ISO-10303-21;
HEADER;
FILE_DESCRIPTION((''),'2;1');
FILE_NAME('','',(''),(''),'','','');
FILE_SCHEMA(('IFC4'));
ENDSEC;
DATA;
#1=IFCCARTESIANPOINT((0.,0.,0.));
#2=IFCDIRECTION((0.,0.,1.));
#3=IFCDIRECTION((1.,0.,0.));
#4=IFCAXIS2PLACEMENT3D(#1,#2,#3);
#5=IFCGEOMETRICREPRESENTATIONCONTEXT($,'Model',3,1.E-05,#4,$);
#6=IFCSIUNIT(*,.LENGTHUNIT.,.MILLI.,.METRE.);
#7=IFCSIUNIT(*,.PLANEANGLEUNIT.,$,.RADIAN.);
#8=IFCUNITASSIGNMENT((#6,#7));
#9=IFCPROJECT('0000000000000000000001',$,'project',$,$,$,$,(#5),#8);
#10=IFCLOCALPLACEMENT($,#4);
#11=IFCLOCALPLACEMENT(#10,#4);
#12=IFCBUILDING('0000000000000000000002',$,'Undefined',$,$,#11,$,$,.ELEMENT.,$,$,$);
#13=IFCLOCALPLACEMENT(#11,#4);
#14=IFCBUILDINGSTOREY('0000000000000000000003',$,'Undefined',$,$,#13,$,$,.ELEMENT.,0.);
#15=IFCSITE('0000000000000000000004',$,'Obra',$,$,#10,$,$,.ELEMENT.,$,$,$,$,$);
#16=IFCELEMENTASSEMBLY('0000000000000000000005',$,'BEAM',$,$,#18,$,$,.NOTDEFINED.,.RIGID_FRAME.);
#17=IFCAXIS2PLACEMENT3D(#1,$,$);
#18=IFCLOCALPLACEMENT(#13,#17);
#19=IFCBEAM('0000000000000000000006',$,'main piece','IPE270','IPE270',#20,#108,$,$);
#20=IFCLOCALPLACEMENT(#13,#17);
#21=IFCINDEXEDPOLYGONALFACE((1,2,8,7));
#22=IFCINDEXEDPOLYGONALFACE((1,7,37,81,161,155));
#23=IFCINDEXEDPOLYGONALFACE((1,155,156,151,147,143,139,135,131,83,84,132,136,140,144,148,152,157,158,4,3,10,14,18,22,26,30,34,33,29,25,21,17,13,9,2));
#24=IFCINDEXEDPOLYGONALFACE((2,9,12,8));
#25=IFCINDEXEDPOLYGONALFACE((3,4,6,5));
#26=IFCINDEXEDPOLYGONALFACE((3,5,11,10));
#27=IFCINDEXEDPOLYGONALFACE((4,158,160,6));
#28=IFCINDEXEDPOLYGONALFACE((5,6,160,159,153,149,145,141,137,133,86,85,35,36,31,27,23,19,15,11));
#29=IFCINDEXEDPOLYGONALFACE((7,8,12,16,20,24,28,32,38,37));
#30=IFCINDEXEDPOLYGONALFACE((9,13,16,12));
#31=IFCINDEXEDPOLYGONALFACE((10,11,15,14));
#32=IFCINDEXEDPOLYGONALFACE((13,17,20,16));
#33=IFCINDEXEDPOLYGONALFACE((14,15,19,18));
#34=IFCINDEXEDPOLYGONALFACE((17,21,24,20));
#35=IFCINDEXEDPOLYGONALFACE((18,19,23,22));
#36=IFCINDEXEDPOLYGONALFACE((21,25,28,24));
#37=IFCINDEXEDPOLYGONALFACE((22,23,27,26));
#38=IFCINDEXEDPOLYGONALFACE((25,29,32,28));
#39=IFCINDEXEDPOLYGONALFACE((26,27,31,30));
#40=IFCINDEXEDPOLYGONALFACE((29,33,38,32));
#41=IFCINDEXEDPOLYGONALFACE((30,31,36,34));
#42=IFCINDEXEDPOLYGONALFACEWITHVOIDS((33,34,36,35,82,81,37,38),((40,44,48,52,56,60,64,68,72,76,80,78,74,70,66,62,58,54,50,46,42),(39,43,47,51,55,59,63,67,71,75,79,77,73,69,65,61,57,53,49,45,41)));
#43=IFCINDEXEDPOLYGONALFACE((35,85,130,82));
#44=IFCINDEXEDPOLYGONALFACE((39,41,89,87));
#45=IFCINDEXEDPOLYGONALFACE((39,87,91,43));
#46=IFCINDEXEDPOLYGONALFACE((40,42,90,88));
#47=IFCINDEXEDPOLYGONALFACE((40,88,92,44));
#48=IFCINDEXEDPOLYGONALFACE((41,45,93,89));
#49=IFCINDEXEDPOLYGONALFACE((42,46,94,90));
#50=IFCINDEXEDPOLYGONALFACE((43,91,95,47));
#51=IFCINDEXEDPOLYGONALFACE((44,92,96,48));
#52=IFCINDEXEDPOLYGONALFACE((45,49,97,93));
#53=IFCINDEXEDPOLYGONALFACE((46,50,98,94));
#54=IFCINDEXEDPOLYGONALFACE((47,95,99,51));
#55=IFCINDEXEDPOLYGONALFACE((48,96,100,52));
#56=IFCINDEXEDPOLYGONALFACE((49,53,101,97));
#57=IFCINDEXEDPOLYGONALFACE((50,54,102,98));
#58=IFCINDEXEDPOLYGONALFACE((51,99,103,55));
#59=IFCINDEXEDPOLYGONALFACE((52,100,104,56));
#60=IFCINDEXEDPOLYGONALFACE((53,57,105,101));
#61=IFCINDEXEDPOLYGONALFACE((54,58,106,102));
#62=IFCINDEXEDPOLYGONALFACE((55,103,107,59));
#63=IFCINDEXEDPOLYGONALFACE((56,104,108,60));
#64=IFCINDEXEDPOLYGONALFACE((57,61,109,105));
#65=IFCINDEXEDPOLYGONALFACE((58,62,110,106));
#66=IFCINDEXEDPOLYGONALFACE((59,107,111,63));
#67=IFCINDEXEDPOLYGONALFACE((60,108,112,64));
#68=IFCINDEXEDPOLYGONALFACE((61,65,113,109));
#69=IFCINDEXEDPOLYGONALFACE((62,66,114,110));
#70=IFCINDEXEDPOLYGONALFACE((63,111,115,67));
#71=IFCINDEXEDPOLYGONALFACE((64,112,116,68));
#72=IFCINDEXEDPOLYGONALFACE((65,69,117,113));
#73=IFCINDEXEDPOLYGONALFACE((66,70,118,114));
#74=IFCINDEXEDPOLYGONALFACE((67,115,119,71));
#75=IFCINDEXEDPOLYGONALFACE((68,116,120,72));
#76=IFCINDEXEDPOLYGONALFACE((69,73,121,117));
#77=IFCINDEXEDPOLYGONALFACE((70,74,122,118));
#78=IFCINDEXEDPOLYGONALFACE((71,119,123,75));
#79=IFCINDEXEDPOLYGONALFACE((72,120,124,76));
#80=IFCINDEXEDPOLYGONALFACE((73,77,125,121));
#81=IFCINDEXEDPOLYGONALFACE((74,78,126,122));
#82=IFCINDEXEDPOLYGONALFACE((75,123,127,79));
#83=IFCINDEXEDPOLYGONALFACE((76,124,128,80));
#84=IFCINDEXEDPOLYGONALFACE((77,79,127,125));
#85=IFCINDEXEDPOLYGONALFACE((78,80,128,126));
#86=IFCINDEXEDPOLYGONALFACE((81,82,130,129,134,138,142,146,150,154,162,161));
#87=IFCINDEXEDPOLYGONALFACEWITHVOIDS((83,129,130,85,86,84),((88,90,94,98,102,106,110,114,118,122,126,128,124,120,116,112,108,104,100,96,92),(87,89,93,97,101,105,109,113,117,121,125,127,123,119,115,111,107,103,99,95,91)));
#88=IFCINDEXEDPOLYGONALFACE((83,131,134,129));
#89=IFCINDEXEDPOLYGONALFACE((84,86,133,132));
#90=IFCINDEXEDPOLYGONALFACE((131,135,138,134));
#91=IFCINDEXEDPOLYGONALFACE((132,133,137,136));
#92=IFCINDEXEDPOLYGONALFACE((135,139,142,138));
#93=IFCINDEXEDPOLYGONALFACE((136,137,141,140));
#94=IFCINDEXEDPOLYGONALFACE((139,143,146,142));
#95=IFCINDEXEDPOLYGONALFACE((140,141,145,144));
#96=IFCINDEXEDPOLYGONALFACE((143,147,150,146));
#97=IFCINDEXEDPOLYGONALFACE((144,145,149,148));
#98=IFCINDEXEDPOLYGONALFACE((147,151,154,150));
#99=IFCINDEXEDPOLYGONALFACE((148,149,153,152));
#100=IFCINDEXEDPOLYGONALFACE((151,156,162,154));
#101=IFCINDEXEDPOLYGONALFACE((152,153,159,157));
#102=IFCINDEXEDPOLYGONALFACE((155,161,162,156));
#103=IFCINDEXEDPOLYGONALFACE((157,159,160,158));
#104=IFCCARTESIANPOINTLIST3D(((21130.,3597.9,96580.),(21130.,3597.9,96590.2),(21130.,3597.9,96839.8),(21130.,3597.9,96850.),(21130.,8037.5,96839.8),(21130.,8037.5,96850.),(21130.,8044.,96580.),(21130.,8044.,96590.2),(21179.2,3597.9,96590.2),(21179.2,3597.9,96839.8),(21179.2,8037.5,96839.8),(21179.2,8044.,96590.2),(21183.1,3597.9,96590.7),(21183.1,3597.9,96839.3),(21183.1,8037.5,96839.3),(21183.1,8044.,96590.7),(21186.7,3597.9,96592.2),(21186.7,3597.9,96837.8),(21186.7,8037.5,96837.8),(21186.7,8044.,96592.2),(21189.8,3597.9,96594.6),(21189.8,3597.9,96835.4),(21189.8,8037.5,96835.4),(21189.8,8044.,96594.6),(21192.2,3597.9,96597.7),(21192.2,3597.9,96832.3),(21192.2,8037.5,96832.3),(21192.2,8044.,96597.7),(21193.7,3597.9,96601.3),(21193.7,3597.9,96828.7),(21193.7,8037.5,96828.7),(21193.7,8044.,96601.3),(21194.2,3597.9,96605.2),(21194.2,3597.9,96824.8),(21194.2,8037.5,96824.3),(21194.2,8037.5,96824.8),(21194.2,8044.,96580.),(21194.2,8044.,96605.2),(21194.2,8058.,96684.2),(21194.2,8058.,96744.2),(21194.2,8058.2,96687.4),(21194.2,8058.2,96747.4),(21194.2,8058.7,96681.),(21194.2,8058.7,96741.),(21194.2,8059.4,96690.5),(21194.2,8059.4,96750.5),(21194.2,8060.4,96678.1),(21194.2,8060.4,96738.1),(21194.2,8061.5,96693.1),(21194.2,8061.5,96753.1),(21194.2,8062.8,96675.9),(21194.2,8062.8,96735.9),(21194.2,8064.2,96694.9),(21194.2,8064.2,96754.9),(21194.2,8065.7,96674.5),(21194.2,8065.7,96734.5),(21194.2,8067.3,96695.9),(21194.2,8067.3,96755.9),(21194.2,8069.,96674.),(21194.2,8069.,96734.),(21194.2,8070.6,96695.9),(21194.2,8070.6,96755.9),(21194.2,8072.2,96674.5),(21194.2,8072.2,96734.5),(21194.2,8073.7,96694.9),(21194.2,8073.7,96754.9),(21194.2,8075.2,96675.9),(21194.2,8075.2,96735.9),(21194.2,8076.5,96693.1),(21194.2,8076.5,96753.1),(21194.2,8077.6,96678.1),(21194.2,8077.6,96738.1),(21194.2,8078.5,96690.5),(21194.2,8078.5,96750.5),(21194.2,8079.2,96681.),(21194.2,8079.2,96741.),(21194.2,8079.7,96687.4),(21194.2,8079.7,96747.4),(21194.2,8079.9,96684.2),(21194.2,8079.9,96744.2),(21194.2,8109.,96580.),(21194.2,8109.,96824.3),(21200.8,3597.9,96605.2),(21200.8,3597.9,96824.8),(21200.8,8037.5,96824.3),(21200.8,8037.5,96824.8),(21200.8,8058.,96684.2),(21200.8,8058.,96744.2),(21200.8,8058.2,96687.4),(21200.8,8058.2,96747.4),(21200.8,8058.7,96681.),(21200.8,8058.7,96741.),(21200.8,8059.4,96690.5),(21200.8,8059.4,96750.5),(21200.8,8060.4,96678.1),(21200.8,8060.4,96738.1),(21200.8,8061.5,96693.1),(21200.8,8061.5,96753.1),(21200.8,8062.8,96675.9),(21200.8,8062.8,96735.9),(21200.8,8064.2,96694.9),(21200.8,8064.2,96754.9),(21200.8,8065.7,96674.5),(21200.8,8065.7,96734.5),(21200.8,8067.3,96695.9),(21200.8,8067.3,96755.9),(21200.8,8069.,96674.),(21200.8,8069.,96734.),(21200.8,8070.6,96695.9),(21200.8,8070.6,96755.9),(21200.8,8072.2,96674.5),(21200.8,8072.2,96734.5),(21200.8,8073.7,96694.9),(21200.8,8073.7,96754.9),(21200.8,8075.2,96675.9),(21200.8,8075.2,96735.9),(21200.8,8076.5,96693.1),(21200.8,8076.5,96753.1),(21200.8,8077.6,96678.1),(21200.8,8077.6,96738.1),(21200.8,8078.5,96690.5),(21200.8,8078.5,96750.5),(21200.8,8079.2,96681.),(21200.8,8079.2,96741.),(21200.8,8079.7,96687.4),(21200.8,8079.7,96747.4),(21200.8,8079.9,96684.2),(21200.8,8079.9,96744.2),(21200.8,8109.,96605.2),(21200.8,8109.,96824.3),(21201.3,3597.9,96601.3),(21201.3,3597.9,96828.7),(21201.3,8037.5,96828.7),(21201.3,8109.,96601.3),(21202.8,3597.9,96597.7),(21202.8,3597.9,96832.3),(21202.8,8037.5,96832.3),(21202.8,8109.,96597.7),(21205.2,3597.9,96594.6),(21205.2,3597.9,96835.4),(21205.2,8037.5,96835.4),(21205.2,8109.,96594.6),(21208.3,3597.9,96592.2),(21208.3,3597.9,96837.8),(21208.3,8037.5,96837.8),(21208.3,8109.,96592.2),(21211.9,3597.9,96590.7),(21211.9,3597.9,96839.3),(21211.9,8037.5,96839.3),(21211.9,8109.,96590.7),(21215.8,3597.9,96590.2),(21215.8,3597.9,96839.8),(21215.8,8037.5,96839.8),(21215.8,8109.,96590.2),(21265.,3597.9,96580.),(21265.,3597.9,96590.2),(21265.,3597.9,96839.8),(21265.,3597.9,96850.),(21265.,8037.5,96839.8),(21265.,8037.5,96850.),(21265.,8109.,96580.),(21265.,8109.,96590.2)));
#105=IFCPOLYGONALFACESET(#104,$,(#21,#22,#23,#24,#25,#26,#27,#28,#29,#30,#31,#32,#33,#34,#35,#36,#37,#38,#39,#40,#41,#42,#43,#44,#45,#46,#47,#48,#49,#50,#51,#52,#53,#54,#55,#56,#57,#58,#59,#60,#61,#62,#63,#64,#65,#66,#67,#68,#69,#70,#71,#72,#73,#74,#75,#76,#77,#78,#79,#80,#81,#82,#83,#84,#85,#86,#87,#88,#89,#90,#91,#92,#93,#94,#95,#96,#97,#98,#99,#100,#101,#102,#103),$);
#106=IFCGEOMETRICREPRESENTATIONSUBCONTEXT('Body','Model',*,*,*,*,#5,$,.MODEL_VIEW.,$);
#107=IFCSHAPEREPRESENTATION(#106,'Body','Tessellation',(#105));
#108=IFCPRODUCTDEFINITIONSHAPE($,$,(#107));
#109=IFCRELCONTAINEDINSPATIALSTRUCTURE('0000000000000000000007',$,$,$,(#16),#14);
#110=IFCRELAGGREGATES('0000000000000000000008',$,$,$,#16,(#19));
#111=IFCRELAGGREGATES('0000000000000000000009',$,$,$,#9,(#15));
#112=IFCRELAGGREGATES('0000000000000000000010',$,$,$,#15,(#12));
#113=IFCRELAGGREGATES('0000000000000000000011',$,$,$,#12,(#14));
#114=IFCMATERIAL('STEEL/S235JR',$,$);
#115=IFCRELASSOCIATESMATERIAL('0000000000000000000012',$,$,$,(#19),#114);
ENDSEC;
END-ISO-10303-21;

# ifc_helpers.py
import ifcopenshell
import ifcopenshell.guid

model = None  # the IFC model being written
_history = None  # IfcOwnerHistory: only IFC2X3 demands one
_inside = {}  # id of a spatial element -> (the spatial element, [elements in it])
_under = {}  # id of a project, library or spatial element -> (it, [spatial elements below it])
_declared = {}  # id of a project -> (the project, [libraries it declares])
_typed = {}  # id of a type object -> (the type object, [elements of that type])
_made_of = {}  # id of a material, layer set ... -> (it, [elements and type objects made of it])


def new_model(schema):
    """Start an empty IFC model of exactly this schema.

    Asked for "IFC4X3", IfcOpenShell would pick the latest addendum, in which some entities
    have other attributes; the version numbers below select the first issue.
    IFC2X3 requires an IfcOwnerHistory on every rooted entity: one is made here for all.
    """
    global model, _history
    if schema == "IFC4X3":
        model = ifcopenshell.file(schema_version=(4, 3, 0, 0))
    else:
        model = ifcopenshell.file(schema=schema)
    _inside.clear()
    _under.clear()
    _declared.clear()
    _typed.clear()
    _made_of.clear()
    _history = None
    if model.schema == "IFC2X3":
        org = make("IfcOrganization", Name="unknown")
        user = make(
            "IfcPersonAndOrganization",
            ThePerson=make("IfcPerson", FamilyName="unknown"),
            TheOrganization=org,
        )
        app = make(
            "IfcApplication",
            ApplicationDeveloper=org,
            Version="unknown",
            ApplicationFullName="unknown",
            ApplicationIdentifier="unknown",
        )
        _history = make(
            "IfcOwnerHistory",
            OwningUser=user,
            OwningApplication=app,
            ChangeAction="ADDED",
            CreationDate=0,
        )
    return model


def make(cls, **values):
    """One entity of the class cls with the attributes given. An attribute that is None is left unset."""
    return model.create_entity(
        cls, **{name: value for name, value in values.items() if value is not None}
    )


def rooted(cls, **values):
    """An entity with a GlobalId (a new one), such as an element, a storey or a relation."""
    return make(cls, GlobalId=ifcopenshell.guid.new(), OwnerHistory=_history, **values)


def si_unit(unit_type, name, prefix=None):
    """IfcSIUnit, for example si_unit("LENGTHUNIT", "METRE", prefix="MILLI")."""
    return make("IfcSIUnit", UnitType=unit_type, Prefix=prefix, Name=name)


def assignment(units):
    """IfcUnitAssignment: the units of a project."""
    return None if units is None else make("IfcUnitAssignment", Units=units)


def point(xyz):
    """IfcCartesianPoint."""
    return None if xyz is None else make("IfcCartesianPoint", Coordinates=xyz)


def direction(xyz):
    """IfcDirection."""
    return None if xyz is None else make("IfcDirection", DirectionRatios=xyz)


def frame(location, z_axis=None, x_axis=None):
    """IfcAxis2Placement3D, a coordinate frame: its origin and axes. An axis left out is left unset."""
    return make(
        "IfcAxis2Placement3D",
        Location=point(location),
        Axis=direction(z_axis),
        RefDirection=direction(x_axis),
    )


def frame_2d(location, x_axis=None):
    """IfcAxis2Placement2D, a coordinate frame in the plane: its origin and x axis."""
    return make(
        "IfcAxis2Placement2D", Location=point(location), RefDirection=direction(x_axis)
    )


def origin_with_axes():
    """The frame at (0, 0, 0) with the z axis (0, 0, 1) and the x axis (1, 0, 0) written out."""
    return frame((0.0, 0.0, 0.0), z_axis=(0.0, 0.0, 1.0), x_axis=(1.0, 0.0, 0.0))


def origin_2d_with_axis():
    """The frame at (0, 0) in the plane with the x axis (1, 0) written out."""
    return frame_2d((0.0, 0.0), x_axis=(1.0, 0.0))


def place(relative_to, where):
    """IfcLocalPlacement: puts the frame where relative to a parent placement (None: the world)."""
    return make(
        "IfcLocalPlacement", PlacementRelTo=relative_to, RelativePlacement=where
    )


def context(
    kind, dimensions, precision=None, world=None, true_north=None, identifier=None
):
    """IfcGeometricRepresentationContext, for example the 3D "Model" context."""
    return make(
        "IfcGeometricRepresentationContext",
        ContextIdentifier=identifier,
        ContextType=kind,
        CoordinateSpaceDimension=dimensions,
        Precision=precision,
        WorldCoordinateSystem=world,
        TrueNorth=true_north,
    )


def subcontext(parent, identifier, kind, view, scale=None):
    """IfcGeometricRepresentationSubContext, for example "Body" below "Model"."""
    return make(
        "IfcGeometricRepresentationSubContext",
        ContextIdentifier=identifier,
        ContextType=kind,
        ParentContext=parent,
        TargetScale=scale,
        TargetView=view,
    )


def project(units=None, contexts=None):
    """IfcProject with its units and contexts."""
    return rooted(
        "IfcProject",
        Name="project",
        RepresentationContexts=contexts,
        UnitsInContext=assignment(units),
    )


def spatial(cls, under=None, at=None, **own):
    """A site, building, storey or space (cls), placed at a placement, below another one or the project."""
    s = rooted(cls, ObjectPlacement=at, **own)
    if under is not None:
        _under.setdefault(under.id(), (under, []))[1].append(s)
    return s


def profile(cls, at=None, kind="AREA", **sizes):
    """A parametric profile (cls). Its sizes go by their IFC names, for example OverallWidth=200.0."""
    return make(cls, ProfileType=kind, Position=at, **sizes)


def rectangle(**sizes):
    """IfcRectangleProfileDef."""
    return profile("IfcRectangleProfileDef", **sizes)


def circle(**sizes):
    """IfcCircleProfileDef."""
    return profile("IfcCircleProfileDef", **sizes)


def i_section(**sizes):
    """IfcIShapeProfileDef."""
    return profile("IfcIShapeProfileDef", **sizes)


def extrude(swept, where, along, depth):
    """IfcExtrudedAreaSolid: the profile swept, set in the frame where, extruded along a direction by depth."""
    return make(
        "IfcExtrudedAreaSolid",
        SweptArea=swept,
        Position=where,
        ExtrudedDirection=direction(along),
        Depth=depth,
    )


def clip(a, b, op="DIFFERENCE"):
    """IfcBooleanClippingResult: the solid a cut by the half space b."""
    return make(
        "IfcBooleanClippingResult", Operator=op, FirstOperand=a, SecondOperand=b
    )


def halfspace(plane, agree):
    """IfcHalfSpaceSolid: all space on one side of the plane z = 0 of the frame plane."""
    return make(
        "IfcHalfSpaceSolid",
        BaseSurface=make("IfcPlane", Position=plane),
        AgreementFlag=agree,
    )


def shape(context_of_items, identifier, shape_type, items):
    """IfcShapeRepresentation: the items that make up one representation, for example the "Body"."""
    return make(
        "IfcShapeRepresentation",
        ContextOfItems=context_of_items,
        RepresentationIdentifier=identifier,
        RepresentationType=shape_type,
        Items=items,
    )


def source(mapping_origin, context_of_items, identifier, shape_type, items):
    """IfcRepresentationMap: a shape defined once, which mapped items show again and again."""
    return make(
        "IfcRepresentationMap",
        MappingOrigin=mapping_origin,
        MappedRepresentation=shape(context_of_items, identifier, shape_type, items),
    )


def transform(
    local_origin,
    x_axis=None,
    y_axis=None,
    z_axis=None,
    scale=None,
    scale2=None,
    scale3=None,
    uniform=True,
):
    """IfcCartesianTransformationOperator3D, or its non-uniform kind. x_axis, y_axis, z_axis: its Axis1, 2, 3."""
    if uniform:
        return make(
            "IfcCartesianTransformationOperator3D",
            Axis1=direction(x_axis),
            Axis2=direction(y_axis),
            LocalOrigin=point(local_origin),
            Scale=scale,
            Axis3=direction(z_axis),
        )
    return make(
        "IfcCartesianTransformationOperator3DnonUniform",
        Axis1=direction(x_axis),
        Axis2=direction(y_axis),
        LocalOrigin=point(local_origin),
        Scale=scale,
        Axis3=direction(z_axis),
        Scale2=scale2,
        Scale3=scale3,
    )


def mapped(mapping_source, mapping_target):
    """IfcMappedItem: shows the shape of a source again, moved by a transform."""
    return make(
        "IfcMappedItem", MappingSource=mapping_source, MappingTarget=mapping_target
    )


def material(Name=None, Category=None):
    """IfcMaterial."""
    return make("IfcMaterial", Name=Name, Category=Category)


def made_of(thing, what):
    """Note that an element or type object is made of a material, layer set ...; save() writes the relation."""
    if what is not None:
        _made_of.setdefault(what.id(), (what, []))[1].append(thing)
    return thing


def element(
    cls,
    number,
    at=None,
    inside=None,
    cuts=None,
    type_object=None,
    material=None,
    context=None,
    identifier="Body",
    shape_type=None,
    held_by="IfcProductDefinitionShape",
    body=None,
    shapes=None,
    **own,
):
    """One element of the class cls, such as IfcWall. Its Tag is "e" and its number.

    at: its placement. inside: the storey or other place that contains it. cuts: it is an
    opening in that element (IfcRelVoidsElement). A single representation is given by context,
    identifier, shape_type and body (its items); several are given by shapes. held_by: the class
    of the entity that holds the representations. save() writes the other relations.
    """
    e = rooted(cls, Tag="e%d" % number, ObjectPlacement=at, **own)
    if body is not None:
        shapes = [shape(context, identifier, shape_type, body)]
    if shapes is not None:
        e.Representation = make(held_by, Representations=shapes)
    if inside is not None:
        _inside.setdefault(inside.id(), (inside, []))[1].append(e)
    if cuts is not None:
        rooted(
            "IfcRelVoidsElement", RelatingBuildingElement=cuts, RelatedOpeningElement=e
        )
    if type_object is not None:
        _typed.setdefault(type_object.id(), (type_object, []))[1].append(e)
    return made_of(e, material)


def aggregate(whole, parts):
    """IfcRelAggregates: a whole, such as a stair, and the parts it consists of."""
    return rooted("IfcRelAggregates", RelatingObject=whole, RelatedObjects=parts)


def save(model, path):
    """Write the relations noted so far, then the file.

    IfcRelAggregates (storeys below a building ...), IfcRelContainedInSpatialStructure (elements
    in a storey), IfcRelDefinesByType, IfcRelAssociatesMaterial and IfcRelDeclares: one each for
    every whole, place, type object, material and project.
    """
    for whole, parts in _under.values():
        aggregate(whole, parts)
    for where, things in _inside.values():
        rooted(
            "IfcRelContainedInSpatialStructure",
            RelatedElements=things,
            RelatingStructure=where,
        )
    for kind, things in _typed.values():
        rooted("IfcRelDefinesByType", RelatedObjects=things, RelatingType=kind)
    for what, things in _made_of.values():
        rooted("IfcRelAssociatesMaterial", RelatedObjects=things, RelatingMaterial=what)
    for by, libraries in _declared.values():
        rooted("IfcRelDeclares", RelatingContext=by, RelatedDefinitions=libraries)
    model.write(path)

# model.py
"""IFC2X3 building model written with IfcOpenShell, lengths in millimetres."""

from ifc_helpers import new_model, si_unit, frame, origin_with_axes, origin_2d_with_axis, place, context, subcontext, project, spatial, rectangle, circle, i_section, extrude, clip, halfspace, source, transform, mapped, material, element, aggregate, save


model = new_model("IFC2X3")

# Units and contexts
model_context = context("Model", 3, precision=1e-05, world=origin_with_axes())
body_context = subcontext(model_context, "Body", "Model", "MODEL_VIEW")
ifc_project = project(units=[si_unit("LENGTHUNIT", "METRE", prefix="MILLI"), si_unit("PLANEANGLEUNIT", "RADIAN")], contexts=[model_context])

# Site, building, storey
site_placement = place(None, origin_with_axes())
site = spatial("IfcSite", under=ifc_project, at=site_placement, Name="Obra", CompositionType="ELEMENT")
building_placement = place(site_placement, origin_with_axes())
building = spatial("IfcBuilding", under=site, at=building_placement, Name="Undefined", CompositionType="ELEMENT")
storey_placement = place(building_placement, origin_with_axes())
storey = spatial("IfcBuildingStorey", under=building, at=storey_placement, Name="Undefined", CompositionType="ELEMENT", Elevation=0.0)

# Shared definitions
ifc_material = material(Name="STEEL/S235JR")

# Element assembly, beam, openings
assembly_1_placement = place(storey_placement, origin_with_axes())
assembly_1 = element("IfcElementAssembly", 1, at=assembly_1_placement, inside=storey, Name="BEAM", AssemblyPlace="NOTDEFINED", PredefinedType="RIGID_FRAME")
beam_1_placement = place(assembly_1_placement, frame((21197.5, 3598.0, 96715.0), z_axis=(0.0, 0.0, 1.0), x_axis=(0.0, 1.0, 0.0)))
beam_1 = element("IfcBeam", 2, at=beam_1_placement, material=ifc_material, Name="main piece", Description="IPE270", ObjectType="IPE270", context=body_context, shape_type="Clipping", body=[
    clip(extrude(i_section(OverallWidth=135.0, OverallDepth=270.0, WebThickness=6.6, FlangeThickness=10.2, FilletRadius=15.0, at=origin_2d_with_axis()), frame((4511.0, 0.0, 0.0), z_axis=(-1.0, 0.0, 0.0), x_axis=(0.0, -1.0, 0.0)), (0.0, 0.0, 1.0), 4511.0), halfspace(frame((4511.0, 0.0, -235.0), z_axis=(-1.0, 0.0, 0.0), x_axis=(0.0, 1.0, 0.0)), True)),
])
opening_1_placement = place(assembly_1_placement, frame((21197.5, 3598.0, 96715.0), z_axis=(0.0, 0.0, 1.0), x_axis=(0.0, 1.0, 0.0)))
element("IfcOpeningElement", 3, at=opening_1_placement, cuts=beam_1, ObjectType="Recess", context=body_context, shape_type="SweptSolid", body=[
    extrude(rectangle(XDim=75.0, YDim=300.0, at=origin_2d_with_axis()), frame((4483.5, 153.3, 124.3), z_axis=(0.0, 0.0, -1.0), x_axis=(-1.0, 0.0, 0.0)), (0.0, 0.0, 1.0), 278.6),
])
opening_2_placement = place(assembly_1_placement, frame((21197.5, 3598.0, 96715.0), z_axis=(0.0, 0.0, 1.0), x_axis=(0.0, 1.0, 0.0)))
element("IfcOpeningElement", 4, at=opening_2_placement, cuts=beam_1, ObjectType="Recess", context=body_context, shape_type="SweptSolid", body=[
    extrude(rectangle(XDim=26.7, YDim=83.5, at=origin_2d_with_axis()), frame((4481.3, 68.5, 122.7), z_axis=(0.0, -1.0, 0.0), x_axis=(0.0, 0.0, -1.0)), (0.0, 0.0, 1.0), 137.0),
])
shared_shape = source(origin_with_axes(), body_context, "Body", "SweptSolid", [
    extrude(circle(Radius=11.0, at=origin_2d_with_axis()), frame((0.0, -3.4, 0.0), z_axis=(0.0, 1.0, 0.0), x_axis=(1.0, 0.0, 0.0)), (0.0, 0.0, 1.0), 6.8),
])
opening_3_placement = place(assembly_1_placement, frame((21197.5, 8109.0, 96850.0), z_axis=(0.0, -1.0, 0.0), x_axis=(0.0, 0.0, -1.0)))
element("IfcOpeningElement", 5, at=opening_3_placement, cuts=beam_1, ObjectType="Opening", context=body_context, shape_type="MappedRepresentation", body=[
    mapped(shared_shape, transform((105.0, 0.0, 40.0))),
    mapped(shared_shape, transform((165.0, 0.0, 40.0))),
])
aggregate(assembly_1, [beam_1])

save(model, "model.ifc")
